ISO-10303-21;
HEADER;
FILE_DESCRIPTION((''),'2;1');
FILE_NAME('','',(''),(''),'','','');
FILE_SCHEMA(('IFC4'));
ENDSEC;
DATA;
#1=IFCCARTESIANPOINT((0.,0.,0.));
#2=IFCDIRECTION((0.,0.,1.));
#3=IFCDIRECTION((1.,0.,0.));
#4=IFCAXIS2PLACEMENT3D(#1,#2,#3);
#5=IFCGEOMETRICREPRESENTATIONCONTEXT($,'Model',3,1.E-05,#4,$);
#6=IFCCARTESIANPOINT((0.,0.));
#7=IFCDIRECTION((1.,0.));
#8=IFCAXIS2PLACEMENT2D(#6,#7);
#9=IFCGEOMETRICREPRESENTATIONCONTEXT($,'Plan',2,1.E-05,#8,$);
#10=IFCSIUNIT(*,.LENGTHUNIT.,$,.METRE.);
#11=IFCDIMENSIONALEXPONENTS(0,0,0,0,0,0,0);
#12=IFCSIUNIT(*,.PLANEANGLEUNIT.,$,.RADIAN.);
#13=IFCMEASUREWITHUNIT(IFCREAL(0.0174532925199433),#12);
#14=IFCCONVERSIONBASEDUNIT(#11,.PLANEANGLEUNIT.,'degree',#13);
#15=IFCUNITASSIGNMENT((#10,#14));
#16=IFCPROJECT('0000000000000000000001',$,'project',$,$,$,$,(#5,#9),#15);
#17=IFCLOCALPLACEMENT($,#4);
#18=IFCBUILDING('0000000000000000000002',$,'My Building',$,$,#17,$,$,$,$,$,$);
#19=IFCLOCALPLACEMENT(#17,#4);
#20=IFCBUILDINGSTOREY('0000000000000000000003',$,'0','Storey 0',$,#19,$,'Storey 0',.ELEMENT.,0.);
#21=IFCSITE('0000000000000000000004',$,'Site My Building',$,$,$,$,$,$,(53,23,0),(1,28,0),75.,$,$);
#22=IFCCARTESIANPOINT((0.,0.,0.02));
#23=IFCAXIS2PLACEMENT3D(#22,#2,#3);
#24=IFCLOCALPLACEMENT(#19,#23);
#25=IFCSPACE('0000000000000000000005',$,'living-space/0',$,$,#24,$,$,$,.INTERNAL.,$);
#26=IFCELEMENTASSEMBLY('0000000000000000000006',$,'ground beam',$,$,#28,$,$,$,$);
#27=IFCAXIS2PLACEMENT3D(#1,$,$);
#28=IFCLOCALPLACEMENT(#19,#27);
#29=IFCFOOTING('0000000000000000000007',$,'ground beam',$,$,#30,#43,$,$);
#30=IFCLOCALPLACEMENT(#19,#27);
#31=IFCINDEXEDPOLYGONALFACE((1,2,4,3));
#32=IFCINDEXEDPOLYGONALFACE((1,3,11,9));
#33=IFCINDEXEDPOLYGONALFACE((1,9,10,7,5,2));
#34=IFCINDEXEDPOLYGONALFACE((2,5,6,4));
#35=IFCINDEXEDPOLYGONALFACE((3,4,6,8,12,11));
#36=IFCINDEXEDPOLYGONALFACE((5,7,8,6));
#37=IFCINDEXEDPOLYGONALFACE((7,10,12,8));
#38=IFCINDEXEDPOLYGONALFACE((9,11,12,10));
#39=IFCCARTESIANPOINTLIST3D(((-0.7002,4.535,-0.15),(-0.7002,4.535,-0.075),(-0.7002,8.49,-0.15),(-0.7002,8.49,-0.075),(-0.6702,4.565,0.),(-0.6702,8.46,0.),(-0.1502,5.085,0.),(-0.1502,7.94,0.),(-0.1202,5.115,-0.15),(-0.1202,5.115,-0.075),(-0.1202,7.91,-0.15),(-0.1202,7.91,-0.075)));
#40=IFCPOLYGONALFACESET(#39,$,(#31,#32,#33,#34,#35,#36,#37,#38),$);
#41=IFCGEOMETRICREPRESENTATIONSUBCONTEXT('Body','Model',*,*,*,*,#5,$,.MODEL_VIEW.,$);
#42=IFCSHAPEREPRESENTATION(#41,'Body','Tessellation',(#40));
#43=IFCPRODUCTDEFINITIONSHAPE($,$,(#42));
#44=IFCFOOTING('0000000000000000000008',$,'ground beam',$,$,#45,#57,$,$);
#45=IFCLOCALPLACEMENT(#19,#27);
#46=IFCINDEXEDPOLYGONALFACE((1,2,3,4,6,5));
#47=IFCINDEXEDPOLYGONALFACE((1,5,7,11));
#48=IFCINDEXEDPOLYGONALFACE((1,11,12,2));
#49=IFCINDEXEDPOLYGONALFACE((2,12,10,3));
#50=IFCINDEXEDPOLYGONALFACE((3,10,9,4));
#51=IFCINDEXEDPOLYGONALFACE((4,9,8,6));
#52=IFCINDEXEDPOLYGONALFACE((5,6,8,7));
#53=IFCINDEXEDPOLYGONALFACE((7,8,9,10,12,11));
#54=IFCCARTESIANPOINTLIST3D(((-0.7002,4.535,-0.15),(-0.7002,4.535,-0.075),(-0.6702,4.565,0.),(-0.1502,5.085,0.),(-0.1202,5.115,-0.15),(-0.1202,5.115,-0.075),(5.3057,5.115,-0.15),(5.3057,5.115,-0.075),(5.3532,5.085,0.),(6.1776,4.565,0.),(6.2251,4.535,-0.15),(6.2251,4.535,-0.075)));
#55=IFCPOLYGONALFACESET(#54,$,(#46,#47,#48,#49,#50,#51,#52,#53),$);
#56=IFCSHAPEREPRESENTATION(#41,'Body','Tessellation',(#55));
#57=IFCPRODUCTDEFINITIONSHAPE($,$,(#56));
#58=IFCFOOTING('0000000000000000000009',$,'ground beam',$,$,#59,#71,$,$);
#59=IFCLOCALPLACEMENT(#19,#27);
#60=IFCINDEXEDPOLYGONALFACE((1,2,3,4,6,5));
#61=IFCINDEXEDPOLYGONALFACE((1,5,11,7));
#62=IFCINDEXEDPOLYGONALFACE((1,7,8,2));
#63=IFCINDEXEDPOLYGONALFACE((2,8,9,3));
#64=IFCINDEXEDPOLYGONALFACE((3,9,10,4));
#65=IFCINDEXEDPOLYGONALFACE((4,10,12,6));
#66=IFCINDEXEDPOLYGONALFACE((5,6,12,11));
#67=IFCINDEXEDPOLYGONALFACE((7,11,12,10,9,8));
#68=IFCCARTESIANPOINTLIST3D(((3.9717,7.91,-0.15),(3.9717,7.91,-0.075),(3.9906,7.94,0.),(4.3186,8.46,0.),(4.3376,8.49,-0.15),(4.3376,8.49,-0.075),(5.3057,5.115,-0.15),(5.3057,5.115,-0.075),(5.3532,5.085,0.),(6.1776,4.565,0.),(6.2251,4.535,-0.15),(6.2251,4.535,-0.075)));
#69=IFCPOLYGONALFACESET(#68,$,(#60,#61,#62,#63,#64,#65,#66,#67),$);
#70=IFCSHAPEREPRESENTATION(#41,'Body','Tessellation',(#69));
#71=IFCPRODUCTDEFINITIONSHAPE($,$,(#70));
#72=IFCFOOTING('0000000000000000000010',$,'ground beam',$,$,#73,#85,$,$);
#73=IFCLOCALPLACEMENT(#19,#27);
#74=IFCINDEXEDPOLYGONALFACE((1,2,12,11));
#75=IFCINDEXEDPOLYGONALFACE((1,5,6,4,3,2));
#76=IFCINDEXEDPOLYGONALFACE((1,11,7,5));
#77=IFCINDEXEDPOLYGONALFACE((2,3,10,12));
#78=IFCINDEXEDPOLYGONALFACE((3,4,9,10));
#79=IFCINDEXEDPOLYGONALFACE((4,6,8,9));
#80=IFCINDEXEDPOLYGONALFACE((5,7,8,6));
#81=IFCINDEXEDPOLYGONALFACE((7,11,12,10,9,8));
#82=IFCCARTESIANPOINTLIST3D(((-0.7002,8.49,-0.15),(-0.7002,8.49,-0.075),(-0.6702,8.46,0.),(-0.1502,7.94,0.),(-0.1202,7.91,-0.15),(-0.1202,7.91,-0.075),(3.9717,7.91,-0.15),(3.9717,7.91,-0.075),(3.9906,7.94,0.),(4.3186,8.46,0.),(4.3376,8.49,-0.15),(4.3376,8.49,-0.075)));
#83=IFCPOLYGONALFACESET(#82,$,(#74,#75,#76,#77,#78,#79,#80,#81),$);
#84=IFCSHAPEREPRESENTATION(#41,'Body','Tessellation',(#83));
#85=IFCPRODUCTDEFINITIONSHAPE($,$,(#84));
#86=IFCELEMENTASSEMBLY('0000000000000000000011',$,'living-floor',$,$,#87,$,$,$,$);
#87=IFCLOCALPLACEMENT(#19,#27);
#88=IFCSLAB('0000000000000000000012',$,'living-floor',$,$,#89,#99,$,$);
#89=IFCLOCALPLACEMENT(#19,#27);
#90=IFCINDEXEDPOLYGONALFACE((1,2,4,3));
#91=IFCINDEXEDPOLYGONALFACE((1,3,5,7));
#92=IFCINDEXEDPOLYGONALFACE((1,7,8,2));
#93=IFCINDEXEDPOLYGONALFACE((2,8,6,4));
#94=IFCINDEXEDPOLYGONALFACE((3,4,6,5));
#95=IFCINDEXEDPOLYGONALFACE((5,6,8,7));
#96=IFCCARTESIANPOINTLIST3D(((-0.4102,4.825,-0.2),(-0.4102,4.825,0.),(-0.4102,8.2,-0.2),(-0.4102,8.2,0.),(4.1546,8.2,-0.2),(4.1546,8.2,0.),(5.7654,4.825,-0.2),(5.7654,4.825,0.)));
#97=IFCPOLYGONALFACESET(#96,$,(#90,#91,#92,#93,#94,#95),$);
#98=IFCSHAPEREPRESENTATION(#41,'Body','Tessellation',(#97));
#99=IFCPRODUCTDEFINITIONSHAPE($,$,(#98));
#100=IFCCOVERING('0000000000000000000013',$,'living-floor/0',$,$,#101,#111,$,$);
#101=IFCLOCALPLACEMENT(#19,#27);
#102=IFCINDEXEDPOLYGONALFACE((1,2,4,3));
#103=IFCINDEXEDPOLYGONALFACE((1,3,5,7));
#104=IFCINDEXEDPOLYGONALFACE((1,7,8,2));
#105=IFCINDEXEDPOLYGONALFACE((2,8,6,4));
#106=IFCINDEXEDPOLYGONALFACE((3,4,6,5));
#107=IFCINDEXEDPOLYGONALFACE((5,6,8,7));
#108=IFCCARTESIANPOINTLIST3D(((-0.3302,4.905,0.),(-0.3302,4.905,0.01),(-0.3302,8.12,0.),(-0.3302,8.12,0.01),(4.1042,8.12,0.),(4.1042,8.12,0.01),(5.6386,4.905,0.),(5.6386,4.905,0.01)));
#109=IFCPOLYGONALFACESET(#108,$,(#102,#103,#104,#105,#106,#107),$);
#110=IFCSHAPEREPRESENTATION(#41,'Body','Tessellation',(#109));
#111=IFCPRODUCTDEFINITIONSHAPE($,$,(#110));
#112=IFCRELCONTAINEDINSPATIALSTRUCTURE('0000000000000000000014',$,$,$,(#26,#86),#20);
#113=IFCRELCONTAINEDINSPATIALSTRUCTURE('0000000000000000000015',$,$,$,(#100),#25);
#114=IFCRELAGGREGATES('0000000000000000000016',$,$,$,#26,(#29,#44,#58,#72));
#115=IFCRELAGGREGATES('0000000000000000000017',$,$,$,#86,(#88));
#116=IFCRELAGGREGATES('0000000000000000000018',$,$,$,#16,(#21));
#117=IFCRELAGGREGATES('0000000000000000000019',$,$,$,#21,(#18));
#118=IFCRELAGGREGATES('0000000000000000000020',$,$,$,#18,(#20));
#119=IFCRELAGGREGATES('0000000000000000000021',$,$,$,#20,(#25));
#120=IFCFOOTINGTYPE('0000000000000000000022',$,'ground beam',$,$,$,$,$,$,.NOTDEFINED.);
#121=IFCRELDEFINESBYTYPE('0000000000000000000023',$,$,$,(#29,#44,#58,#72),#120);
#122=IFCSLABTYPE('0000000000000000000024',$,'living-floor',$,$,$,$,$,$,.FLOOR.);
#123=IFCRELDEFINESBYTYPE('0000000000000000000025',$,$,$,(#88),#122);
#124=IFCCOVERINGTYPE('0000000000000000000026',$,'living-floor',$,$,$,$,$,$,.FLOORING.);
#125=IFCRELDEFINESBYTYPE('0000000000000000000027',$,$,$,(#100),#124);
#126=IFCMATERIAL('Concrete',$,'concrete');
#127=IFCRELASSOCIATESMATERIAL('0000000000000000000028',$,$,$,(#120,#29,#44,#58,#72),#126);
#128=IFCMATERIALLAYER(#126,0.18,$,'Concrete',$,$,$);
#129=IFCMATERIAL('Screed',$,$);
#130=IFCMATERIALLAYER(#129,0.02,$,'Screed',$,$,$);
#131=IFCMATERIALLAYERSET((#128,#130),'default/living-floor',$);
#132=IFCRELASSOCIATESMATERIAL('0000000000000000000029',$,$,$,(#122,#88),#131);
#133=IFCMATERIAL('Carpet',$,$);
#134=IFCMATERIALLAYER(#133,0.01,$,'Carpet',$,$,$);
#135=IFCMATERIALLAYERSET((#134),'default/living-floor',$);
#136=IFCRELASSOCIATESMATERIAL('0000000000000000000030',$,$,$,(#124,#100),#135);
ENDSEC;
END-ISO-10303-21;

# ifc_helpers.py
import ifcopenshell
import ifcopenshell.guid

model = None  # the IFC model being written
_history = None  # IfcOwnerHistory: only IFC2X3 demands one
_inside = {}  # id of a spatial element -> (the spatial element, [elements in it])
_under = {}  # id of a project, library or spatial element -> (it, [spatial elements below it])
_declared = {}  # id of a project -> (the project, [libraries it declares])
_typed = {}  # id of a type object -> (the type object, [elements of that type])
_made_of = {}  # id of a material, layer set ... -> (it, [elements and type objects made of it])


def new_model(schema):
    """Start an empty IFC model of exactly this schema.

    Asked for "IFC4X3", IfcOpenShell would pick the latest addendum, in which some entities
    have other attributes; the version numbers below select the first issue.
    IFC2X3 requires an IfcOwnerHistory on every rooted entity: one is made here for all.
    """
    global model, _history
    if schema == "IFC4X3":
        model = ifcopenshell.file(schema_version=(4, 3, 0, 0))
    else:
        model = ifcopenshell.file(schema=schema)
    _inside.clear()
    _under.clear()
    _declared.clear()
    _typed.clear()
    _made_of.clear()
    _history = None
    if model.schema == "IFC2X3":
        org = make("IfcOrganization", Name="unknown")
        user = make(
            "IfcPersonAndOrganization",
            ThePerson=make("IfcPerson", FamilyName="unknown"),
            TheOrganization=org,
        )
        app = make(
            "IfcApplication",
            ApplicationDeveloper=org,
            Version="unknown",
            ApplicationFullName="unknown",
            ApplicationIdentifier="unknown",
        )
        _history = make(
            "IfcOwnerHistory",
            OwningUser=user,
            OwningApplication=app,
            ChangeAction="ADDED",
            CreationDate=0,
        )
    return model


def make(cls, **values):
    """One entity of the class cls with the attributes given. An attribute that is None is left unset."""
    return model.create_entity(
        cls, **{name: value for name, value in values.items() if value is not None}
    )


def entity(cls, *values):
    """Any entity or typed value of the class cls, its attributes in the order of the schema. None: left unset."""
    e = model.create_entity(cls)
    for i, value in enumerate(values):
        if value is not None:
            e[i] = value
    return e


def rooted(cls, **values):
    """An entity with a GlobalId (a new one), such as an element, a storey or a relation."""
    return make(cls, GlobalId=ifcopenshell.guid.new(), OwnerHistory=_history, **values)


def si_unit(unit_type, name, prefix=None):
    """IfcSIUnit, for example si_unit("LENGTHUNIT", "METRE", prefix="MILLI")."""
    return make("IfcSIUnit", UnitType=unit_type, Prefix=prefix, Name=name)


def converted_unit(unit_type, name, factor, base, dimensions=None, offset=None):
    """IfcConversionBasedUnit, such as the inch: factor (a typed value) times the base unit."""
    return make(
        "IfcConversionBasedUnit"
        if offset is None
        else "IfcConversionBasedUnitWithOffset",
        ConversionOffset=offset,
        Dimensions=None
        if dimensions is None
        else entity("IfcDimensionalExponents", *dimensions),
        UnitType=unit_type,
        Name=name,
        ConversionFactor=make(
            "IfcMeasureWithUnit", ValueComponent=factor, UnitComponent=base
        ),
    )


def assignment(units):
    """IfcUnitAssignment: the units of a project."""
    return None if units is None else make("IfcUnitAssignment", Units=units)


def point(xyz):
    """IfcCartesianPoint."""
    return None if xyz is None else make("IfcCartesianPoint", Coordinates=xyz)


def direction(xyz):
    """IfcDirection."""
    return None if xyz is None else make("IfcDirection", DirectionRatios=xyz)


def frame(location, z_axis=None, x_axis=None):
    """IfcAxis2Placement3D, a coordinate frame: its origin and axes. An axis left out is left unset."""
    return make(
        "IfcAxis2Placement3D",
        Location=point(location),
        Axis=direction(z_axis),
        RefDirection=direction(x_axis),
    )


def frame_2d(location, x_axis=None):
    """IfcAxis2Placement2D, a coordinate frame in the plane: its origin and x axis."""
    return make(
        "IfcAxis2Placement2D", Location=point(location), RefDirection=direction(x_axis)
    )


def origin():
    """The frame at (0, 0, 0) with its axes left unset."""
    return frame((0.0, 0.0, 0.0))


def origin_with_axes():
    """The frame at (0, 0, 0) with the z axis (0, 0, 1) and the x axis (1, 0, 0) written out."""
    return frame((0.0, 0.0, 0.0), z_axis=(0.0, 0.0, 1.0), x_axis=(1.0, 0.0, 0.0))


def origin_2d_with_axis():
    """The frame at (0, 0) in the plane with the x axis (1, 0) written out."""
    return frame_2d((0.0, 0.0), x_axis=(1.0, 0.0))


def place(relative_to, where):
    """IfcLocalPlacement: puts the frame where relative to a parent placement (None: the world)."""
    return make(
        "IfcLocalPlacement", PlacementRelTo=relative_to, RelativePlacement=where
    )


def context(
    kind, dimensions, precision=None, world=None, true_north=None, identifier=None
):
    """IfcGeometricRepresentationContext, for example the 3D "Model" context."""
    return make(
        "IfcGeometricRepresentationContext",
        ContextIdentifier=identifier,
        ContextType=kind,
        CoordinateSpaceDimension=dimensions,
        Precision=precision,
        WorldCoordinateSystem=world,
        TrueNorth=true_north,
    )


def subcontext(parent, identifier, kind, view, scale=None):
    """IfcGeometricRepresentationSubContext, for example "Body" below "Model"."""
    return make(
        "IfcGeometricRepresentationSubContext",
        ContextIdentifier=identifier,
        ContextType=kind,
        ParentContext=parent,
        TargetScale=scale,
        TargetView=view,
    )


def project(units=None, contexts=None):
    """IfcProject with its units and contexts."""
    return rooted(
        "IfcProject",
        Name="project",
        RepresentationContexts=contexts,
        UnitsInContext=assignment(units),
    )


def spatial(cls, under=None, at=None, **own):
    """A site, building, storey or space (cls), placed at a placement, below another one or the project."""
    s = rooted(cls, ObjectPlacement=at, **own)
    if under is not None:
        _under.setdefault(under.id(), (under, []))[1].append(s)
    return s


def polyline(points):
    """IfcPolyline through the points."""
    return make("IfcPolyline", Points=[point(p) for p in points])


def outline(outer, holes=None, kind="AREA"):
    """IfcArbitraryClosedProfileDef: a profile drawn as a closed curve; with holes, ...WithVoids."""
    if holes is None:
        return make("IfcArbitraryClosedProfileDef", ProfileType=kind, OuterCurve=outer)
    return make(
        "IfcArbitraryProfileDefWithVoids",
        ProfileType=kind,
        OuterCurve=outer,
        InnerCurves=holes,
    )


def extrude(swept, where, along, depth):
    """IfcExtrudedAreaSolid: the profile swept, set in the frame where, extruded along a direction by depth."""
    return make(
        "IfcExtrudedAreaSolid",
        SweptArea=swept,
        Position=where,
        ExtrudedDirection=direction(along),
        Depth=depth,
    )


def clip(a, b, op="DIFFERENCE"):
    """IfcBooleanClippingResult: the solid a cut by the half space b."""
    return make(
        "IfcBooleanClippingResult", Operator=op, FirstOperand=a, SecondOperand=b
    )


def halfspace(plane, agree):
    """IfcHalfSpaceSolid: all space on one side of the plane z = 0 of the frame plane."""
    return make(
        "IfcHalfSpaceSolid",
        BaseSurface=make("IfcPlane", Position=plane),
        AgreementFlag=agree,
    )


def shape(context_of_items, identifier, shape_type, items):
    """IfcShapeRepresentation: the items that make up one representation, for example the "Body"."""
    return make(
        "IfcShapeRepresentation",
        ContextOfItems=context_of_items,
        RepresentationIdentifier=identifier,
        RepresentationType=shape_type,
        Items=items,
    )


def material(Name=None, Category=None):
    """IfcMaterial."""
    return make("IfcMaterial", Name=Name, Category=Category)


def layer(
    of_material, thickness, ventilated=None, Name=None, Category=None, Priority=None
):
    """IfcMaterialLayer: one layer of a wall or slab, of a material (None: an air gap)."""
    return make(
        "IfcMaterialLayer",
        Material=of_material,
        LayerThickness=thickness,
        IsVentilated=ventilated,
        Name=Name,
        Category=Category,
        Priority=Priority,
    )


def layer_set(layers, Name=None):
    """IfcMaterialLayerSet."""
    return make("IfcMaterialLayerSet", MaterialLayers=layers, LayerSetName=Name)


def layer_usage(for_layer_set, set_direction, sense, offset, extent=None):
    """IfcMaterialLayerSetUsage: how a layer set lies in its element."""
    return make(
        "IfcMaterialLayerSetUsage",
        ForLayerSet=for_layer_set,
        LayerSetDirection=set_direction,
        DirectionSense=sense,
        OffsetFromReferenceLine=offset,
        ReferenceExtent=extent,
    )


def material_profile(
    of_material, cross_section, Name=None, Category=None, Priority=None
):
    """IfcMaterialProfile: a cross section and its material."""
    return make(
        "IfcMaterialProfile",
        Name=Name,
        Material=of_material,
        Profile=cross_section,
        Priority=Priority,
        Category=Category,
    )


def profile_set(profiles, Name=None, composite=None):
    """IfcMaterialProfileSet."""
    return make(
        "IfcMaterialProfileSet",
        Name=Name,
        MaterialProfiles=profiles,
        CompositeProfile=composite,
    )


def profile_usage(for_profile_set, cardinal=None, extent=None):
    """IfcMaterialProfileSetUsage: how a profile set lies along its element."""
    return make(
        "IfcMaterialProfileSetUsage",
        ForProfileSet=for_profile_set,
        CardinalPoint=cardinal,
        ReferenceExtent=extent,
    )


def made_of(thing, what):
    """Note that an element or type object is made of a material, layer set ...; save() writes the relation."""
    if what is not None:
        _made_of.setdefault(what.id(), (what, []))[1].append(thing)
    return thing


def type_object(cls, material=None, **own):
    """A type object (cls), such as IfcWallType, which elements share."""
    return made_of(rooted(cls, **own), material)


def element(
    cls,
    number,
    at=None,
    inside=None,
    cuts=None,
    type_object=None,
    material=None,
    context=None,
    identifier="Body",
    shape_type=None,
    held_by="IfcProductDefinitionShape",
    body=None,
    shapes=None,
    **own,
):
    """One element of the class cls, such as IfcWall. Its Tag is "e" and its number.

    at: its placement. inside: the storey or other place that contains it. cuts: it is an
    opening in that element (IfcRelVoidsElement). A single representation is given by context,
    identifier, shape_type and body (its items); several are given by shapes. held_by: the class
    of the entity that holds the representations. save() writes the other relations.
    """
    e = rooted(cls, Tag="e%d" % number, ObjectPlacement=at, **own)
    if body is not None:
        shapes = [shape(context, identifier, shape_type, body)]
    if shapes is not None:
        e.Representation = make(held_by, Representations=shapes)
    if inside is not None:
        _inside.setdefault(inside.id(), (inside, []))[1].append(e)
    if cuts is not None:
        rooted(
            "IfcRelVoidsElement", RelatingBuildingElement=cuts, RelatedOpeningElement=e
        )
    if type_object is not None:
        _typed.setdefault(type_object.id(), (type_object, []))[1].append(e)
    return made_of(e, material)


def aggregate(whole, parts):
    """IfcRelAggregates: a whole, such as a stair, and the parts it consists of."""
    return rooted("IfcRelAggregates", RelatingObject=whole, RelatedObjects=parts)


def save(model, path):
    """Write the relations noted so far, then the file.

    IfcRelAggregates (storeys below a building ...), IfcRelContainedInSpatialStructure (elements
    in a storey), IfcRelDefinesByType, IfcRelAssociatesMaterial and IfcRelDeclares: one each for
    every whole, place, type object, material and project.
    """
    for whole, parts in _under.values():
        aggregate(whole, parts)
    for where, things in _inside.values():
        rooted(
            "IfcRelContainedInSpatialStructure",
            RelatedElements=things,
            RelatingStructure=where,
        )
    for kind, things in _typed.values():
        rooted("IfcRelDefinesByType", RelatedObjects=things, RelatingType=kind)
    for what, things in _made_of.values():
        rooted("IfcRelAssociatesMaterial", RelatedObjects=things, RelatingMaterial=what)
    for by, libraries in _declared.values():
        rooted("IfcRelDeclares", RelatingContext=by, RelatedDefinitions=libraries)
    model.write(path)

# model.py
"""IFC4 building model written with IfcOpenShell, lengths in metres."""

from ifc_helpers import new_model, entity, si_unit, converted_unit, frame, origin, origin_with_axes, origin_2d_with_axis, place, context, subcontext, project, spatial, polyline, outline, extrude, clip, halfspace, material, layer, layer_set, layer_usage, material_profile, profile_set, profile_usage, type_object, element, aggregate, save


model = new_model("IFC4")

# Units and contexts
model_context = context("Model", 3, precision=1e-05, world=origin_with_axes())
plan_context = context("Plan", 2, precision=1e-05, world=origin_2d_with_axis())
body_context = subcontext(model_context, "Body", "Model", "MODEL_VIEW")
ifc_project = project(units=[si_unit("LENGTHUNIT", "METRE"), converted_unit("PLANEANGLEUNIT", "degree", entity("IfcReal", 0.0174532925199433), si_unit("PLANEANGLEUNIT", "RADIAN"), dimensions=[0, 0, 0, 0, 0, 0, 0])], contexts=[model_context, plan_context])

# Site, building, storey
site = spatial("IfcSite", under=ifc_project, Name="Site My Building", RefLatitude=(53, 23, 0), RefLongitude=(1, 28, 0), RefElevation=75.0)
building_placement = place(None, origin_with_axes())
building = spatial("IfcBuilding", under=site, at=building_placement, Name="My Building")
storey_placement = place(building_placement, origin_with_axes())
storey = spatial("IfcBuildingStorey", under=building, at=storey_placement, Name="0", Description="Storey 0", LongName="Storey 0", CompositionType="ELEMENT", Elevation=0.0)

# Element assembly, footings
assembly_1_placement = place(storey_placement, origin_with_axes())
assembly_1 = element("IfcElementAssembly", 1, at=assembly_1_placement, inside=storey, Name="ground beam")
ifc_material_1 = material(Name="Concrete", Category="concrete")
ifc_material_profile = material_profile(ifc_material_1, outline(polyline([(-0.26, 0.0), (-0.29, -0.075), (-0.29, -0.15), (0.29, -0.15), (0.29, -0.075), (0.26, 0.0), (-0.26, 0.0)])))
ifc_profile_set = profile_set([ifc_material_profile])
ifc_profile_usage_1 = profile_usage(ifc_profile_set)
footing_type = type_object("IfcFootingType", Name="ground beam", PredefinedType="NOTDEFINED", material=ifc_profile_set)
footing_1_placement = place(assembly_1_placement, frame((-0.4102, 3.825, 0.0), z_axis=(0.0, 1.0, 0.0), x_axis=(-1.0, 0.0, 0.0)))
footing_1 = element("IfcFooting", 2, at=footing_1_placement, type_object=footing_type, material=ifc_profile_usage_1, Name="ground beam", context=body_context, shape_type="Clipping", body=[
    clip(clip(extrude(outline(polyline([(-0.26, 0.0), (-0.29, -0.075), (-0.29, -0.15), (0.29, -0.15), (0.29, -0.075), (0.26, 0.0), (-0.26, 0.0)])), origin_with_axes(), (0.0, 0.0, 1.0), 5.375), halfspace(frame((0.0, 0.0, 1.0), z_axis=(-0.707107, 0.0, -0.707107), x_axis=(0.0, 1.0, 0.0)), False)), halfspace(frame((0.0, 0.0, 4.375), z_axis=(-0.707107, 0.0, 0.707107), x_axis=(0.0, 1.0, 0.0)), False)),
])
ifc_profile_usage_2 = profile_usage(ifc_profile_set)
footing_2_placement = place(assembly_1_placement, frame((6.7654, 4.825, 0.0), z_axis=(-1.0, 0.0, 0.0), x_axis=(0.0, -1.0, 0.0)))
footing_2 = element("IfcFooting", 3, at=footing_2_placement, type_object=footing_type, material=ifc_profile_usage_2, Name="ground beam", context=body_context, shape_type="Clipping", body=[
    clip(clip(extrude(outline(polyline([(-0.26, 0.0), (-0.29, -0.075), (-0.29, -0.15), (0.29, -0.15), (0.29, -0.075), (0.26, 0.0), (-0.26, 0.0)])), origin_with_axes(), (0.0, 0.0, 1.0), 8.1756), halfspace(frame((0.0, 0.0, 1.0), z_axis=(-0.845791, 0.0, -0.533515), x_axis=(0.0, 1.0, 0.0)), False)), halfspace(frame((0.0, 0.0, 7.1756), z_axis=(-0.707107, 0.0, 0.707107), x_axis=(0.0, 1.0, 0.0)), False)),
])
ifc_profile_usage_3 = profile_usage(ifc_profile_set)
footing_3_placement = place(assembly_1_placement, frame((3.7239, 9.1025, 0.0), z_axis=(0.430724, -0.902484, 0.0), x_axis=(0.902484, 0.430724, 0.0)))
footing_3 = element("IfcFooting", 4, at=footing_3_placement, type_object=footing_type, material=ifc_profile_usage_3, Name="ground beam", context=body_context, shape_type="Clipping", body=[
    clip(clip(extrude(outline(polyline([(-0.26, 0.0), (-0.29, -0.075), (-0.29, -0.15), (0.29, -0.15), (0.29, -0.075), (0.26, 0.0), (-0.26, 0.0)])), origin_with_axes(), (0.0, 0.0, 1.0), 5.7397), halfspace(frame((0.0, 0.0, 1.0), z_axis=(-0.533515, 0.0, -0.845791), x_axis=(0.0, 1.0, 0.0)), False)), halfspace(frame((0.0, 0.0, 4.7397), z_axis=(-0.845791, 0.0, 0.533515), x_axis=(0.0, 1.0, 0.0)), False)),
])
ifc_profile_usage_4 = profile_usage(ifc_profile_set)
footing_4_placement = place(assembly_1_placement, frame((-1.4102, 8.2, 0.0), z_axis=(1.0, 0.0, 0.0), x_axis=(0.0, 1.0, 0.0)))
footing_4 = element("IfcFooting", 5, at=footing_4_placement, type_object=footing_type, material=ifc_profile_usage_4, Name="ground beam", context=body_context, shape_type="Clipping", body=[
    clip(clip(extrude(outline(polyline([(-0.26, 0.0), (-0.29, -0.075), (-0.29, -0.15), (0.29, -0.15), (0.29, -0.075), (0.26, 0.0), (-0.26, 0.0)])), origin_with_axes(), (0.0, 0.0, 1.0), 6.5648), halfspace(frame((0.0, 0.0, 1.0), z_axis=(-0.707107, 0.0, -0.707107), x_axis=(0.0, 1.0, 0.0)), False)), halfspace(frame((0.0, 0.0, 5.5648), z_axis=(-0.533515, 0.0, 0.845791), x_axis=(0.0, 1.0, 0.0)), False)),
])
aggregate(assembly_1, [footing_1, footing_2, footing_3, footing_4])

# Element assembly, slab
assembly_2_placement = place(storey_placement, origin_with_axes())
assembly_2 = element("IfcElementAssembly", 6, at=assembly_2_placement, inside=storey, Name="living-floor")
ifc_layer_1 = layer(ifc_material_1, 0.18, Name="Concrete")
ifc_material_2 = material(Name="Screed")
ifc_layer_2 = layer(ifc_material_2, 0.02, Name="Screed")
ifc_layer_set_1 = layer_set([ifc_layer_1, ifc_layer_2], Name="default/living-floor")
ifc_layer_usage_1 = layer_usage(ifc_layer_set_1, "AXIS3", "POSITIVE", 0.0)
slab_type = type_object("IfcSlabType", Name="living-floor", PredefinedType="FLOOR", material=ifc_layer_set_1)
slab_placement = place(assembly_2_placement, frame((4.1546, 8.2, -0.2), z_axis=(0.0, 0.0, -1.0), x_axis=(0.0, 1.0, 0.0)))
slab = element("IfcSlab", 7, at=slab_placement, type_object=slab_type, material=ifc_layer_usage_1, Name="living-floor", context=body_context, shape_type="SweptSolid", body=[
    extrude(outline(polyline([(0.0, 0.0), (-3.375, 1.6108), (-3.375, -4.5648), (0.0, -4.5648), (0.0, 0.0)])), origin(), (0.0, 0.0, -1.0), 0.2),
])
aggregate(assembly_2, [slab])

# Shared definitions
space_placement = place(storey_placement, frame((0.0, 0.0, 0.02), z_axis=(0.0, 0.0, 1.0), x_axis=(1.0, 0.0, 0.0)))
space = spatial("IfcSpace", under=storey, at=space_placement, Name="living-space/0", PredefinedType="INTERNAL")

# Covering
ifc_material_3 = material(Name="Carpet")
ifc_layer_3 = layer(ifc_material_3, 0.01, Name="Carpet")
ifc_layer_set_2 = layer_set([ifc_layer_3], Name="default/living-floor")
ifc_layer_usage_2 = layer_usage(ifc_layer_set_2, "AXIS2", "POSITIVE", 0.0)
covering_type = type_object("IfcCoveringType", Name="living-floor", PredefinedType="FLOORING", material=ifc_layer_set_2)
covering_placement = place(space_placement, frame((0.0, 0.0, -0.02), z_axis=(0.0, 0.0, 1.0), x_axis=(1.0, 0.0, 0.0)))
element("IfcCovering", 8, at=covering_placement, inside=space, type_object=covering_type, material=ifc_layer_usage_2, Name="living-floor/0", context=body_context, shape_type="SweptSolid", body=[
    extrude(outline(polyline([(4.1042, 8.12), (-0.3302, 8.12), (-0.3302, 4.905), (5.6386, 4.905), (4.1042, 8.12)])), origin_with_axes(), (0.0, 0.0, 1.0), 0.01),
])

save(model, "model.ifc")
